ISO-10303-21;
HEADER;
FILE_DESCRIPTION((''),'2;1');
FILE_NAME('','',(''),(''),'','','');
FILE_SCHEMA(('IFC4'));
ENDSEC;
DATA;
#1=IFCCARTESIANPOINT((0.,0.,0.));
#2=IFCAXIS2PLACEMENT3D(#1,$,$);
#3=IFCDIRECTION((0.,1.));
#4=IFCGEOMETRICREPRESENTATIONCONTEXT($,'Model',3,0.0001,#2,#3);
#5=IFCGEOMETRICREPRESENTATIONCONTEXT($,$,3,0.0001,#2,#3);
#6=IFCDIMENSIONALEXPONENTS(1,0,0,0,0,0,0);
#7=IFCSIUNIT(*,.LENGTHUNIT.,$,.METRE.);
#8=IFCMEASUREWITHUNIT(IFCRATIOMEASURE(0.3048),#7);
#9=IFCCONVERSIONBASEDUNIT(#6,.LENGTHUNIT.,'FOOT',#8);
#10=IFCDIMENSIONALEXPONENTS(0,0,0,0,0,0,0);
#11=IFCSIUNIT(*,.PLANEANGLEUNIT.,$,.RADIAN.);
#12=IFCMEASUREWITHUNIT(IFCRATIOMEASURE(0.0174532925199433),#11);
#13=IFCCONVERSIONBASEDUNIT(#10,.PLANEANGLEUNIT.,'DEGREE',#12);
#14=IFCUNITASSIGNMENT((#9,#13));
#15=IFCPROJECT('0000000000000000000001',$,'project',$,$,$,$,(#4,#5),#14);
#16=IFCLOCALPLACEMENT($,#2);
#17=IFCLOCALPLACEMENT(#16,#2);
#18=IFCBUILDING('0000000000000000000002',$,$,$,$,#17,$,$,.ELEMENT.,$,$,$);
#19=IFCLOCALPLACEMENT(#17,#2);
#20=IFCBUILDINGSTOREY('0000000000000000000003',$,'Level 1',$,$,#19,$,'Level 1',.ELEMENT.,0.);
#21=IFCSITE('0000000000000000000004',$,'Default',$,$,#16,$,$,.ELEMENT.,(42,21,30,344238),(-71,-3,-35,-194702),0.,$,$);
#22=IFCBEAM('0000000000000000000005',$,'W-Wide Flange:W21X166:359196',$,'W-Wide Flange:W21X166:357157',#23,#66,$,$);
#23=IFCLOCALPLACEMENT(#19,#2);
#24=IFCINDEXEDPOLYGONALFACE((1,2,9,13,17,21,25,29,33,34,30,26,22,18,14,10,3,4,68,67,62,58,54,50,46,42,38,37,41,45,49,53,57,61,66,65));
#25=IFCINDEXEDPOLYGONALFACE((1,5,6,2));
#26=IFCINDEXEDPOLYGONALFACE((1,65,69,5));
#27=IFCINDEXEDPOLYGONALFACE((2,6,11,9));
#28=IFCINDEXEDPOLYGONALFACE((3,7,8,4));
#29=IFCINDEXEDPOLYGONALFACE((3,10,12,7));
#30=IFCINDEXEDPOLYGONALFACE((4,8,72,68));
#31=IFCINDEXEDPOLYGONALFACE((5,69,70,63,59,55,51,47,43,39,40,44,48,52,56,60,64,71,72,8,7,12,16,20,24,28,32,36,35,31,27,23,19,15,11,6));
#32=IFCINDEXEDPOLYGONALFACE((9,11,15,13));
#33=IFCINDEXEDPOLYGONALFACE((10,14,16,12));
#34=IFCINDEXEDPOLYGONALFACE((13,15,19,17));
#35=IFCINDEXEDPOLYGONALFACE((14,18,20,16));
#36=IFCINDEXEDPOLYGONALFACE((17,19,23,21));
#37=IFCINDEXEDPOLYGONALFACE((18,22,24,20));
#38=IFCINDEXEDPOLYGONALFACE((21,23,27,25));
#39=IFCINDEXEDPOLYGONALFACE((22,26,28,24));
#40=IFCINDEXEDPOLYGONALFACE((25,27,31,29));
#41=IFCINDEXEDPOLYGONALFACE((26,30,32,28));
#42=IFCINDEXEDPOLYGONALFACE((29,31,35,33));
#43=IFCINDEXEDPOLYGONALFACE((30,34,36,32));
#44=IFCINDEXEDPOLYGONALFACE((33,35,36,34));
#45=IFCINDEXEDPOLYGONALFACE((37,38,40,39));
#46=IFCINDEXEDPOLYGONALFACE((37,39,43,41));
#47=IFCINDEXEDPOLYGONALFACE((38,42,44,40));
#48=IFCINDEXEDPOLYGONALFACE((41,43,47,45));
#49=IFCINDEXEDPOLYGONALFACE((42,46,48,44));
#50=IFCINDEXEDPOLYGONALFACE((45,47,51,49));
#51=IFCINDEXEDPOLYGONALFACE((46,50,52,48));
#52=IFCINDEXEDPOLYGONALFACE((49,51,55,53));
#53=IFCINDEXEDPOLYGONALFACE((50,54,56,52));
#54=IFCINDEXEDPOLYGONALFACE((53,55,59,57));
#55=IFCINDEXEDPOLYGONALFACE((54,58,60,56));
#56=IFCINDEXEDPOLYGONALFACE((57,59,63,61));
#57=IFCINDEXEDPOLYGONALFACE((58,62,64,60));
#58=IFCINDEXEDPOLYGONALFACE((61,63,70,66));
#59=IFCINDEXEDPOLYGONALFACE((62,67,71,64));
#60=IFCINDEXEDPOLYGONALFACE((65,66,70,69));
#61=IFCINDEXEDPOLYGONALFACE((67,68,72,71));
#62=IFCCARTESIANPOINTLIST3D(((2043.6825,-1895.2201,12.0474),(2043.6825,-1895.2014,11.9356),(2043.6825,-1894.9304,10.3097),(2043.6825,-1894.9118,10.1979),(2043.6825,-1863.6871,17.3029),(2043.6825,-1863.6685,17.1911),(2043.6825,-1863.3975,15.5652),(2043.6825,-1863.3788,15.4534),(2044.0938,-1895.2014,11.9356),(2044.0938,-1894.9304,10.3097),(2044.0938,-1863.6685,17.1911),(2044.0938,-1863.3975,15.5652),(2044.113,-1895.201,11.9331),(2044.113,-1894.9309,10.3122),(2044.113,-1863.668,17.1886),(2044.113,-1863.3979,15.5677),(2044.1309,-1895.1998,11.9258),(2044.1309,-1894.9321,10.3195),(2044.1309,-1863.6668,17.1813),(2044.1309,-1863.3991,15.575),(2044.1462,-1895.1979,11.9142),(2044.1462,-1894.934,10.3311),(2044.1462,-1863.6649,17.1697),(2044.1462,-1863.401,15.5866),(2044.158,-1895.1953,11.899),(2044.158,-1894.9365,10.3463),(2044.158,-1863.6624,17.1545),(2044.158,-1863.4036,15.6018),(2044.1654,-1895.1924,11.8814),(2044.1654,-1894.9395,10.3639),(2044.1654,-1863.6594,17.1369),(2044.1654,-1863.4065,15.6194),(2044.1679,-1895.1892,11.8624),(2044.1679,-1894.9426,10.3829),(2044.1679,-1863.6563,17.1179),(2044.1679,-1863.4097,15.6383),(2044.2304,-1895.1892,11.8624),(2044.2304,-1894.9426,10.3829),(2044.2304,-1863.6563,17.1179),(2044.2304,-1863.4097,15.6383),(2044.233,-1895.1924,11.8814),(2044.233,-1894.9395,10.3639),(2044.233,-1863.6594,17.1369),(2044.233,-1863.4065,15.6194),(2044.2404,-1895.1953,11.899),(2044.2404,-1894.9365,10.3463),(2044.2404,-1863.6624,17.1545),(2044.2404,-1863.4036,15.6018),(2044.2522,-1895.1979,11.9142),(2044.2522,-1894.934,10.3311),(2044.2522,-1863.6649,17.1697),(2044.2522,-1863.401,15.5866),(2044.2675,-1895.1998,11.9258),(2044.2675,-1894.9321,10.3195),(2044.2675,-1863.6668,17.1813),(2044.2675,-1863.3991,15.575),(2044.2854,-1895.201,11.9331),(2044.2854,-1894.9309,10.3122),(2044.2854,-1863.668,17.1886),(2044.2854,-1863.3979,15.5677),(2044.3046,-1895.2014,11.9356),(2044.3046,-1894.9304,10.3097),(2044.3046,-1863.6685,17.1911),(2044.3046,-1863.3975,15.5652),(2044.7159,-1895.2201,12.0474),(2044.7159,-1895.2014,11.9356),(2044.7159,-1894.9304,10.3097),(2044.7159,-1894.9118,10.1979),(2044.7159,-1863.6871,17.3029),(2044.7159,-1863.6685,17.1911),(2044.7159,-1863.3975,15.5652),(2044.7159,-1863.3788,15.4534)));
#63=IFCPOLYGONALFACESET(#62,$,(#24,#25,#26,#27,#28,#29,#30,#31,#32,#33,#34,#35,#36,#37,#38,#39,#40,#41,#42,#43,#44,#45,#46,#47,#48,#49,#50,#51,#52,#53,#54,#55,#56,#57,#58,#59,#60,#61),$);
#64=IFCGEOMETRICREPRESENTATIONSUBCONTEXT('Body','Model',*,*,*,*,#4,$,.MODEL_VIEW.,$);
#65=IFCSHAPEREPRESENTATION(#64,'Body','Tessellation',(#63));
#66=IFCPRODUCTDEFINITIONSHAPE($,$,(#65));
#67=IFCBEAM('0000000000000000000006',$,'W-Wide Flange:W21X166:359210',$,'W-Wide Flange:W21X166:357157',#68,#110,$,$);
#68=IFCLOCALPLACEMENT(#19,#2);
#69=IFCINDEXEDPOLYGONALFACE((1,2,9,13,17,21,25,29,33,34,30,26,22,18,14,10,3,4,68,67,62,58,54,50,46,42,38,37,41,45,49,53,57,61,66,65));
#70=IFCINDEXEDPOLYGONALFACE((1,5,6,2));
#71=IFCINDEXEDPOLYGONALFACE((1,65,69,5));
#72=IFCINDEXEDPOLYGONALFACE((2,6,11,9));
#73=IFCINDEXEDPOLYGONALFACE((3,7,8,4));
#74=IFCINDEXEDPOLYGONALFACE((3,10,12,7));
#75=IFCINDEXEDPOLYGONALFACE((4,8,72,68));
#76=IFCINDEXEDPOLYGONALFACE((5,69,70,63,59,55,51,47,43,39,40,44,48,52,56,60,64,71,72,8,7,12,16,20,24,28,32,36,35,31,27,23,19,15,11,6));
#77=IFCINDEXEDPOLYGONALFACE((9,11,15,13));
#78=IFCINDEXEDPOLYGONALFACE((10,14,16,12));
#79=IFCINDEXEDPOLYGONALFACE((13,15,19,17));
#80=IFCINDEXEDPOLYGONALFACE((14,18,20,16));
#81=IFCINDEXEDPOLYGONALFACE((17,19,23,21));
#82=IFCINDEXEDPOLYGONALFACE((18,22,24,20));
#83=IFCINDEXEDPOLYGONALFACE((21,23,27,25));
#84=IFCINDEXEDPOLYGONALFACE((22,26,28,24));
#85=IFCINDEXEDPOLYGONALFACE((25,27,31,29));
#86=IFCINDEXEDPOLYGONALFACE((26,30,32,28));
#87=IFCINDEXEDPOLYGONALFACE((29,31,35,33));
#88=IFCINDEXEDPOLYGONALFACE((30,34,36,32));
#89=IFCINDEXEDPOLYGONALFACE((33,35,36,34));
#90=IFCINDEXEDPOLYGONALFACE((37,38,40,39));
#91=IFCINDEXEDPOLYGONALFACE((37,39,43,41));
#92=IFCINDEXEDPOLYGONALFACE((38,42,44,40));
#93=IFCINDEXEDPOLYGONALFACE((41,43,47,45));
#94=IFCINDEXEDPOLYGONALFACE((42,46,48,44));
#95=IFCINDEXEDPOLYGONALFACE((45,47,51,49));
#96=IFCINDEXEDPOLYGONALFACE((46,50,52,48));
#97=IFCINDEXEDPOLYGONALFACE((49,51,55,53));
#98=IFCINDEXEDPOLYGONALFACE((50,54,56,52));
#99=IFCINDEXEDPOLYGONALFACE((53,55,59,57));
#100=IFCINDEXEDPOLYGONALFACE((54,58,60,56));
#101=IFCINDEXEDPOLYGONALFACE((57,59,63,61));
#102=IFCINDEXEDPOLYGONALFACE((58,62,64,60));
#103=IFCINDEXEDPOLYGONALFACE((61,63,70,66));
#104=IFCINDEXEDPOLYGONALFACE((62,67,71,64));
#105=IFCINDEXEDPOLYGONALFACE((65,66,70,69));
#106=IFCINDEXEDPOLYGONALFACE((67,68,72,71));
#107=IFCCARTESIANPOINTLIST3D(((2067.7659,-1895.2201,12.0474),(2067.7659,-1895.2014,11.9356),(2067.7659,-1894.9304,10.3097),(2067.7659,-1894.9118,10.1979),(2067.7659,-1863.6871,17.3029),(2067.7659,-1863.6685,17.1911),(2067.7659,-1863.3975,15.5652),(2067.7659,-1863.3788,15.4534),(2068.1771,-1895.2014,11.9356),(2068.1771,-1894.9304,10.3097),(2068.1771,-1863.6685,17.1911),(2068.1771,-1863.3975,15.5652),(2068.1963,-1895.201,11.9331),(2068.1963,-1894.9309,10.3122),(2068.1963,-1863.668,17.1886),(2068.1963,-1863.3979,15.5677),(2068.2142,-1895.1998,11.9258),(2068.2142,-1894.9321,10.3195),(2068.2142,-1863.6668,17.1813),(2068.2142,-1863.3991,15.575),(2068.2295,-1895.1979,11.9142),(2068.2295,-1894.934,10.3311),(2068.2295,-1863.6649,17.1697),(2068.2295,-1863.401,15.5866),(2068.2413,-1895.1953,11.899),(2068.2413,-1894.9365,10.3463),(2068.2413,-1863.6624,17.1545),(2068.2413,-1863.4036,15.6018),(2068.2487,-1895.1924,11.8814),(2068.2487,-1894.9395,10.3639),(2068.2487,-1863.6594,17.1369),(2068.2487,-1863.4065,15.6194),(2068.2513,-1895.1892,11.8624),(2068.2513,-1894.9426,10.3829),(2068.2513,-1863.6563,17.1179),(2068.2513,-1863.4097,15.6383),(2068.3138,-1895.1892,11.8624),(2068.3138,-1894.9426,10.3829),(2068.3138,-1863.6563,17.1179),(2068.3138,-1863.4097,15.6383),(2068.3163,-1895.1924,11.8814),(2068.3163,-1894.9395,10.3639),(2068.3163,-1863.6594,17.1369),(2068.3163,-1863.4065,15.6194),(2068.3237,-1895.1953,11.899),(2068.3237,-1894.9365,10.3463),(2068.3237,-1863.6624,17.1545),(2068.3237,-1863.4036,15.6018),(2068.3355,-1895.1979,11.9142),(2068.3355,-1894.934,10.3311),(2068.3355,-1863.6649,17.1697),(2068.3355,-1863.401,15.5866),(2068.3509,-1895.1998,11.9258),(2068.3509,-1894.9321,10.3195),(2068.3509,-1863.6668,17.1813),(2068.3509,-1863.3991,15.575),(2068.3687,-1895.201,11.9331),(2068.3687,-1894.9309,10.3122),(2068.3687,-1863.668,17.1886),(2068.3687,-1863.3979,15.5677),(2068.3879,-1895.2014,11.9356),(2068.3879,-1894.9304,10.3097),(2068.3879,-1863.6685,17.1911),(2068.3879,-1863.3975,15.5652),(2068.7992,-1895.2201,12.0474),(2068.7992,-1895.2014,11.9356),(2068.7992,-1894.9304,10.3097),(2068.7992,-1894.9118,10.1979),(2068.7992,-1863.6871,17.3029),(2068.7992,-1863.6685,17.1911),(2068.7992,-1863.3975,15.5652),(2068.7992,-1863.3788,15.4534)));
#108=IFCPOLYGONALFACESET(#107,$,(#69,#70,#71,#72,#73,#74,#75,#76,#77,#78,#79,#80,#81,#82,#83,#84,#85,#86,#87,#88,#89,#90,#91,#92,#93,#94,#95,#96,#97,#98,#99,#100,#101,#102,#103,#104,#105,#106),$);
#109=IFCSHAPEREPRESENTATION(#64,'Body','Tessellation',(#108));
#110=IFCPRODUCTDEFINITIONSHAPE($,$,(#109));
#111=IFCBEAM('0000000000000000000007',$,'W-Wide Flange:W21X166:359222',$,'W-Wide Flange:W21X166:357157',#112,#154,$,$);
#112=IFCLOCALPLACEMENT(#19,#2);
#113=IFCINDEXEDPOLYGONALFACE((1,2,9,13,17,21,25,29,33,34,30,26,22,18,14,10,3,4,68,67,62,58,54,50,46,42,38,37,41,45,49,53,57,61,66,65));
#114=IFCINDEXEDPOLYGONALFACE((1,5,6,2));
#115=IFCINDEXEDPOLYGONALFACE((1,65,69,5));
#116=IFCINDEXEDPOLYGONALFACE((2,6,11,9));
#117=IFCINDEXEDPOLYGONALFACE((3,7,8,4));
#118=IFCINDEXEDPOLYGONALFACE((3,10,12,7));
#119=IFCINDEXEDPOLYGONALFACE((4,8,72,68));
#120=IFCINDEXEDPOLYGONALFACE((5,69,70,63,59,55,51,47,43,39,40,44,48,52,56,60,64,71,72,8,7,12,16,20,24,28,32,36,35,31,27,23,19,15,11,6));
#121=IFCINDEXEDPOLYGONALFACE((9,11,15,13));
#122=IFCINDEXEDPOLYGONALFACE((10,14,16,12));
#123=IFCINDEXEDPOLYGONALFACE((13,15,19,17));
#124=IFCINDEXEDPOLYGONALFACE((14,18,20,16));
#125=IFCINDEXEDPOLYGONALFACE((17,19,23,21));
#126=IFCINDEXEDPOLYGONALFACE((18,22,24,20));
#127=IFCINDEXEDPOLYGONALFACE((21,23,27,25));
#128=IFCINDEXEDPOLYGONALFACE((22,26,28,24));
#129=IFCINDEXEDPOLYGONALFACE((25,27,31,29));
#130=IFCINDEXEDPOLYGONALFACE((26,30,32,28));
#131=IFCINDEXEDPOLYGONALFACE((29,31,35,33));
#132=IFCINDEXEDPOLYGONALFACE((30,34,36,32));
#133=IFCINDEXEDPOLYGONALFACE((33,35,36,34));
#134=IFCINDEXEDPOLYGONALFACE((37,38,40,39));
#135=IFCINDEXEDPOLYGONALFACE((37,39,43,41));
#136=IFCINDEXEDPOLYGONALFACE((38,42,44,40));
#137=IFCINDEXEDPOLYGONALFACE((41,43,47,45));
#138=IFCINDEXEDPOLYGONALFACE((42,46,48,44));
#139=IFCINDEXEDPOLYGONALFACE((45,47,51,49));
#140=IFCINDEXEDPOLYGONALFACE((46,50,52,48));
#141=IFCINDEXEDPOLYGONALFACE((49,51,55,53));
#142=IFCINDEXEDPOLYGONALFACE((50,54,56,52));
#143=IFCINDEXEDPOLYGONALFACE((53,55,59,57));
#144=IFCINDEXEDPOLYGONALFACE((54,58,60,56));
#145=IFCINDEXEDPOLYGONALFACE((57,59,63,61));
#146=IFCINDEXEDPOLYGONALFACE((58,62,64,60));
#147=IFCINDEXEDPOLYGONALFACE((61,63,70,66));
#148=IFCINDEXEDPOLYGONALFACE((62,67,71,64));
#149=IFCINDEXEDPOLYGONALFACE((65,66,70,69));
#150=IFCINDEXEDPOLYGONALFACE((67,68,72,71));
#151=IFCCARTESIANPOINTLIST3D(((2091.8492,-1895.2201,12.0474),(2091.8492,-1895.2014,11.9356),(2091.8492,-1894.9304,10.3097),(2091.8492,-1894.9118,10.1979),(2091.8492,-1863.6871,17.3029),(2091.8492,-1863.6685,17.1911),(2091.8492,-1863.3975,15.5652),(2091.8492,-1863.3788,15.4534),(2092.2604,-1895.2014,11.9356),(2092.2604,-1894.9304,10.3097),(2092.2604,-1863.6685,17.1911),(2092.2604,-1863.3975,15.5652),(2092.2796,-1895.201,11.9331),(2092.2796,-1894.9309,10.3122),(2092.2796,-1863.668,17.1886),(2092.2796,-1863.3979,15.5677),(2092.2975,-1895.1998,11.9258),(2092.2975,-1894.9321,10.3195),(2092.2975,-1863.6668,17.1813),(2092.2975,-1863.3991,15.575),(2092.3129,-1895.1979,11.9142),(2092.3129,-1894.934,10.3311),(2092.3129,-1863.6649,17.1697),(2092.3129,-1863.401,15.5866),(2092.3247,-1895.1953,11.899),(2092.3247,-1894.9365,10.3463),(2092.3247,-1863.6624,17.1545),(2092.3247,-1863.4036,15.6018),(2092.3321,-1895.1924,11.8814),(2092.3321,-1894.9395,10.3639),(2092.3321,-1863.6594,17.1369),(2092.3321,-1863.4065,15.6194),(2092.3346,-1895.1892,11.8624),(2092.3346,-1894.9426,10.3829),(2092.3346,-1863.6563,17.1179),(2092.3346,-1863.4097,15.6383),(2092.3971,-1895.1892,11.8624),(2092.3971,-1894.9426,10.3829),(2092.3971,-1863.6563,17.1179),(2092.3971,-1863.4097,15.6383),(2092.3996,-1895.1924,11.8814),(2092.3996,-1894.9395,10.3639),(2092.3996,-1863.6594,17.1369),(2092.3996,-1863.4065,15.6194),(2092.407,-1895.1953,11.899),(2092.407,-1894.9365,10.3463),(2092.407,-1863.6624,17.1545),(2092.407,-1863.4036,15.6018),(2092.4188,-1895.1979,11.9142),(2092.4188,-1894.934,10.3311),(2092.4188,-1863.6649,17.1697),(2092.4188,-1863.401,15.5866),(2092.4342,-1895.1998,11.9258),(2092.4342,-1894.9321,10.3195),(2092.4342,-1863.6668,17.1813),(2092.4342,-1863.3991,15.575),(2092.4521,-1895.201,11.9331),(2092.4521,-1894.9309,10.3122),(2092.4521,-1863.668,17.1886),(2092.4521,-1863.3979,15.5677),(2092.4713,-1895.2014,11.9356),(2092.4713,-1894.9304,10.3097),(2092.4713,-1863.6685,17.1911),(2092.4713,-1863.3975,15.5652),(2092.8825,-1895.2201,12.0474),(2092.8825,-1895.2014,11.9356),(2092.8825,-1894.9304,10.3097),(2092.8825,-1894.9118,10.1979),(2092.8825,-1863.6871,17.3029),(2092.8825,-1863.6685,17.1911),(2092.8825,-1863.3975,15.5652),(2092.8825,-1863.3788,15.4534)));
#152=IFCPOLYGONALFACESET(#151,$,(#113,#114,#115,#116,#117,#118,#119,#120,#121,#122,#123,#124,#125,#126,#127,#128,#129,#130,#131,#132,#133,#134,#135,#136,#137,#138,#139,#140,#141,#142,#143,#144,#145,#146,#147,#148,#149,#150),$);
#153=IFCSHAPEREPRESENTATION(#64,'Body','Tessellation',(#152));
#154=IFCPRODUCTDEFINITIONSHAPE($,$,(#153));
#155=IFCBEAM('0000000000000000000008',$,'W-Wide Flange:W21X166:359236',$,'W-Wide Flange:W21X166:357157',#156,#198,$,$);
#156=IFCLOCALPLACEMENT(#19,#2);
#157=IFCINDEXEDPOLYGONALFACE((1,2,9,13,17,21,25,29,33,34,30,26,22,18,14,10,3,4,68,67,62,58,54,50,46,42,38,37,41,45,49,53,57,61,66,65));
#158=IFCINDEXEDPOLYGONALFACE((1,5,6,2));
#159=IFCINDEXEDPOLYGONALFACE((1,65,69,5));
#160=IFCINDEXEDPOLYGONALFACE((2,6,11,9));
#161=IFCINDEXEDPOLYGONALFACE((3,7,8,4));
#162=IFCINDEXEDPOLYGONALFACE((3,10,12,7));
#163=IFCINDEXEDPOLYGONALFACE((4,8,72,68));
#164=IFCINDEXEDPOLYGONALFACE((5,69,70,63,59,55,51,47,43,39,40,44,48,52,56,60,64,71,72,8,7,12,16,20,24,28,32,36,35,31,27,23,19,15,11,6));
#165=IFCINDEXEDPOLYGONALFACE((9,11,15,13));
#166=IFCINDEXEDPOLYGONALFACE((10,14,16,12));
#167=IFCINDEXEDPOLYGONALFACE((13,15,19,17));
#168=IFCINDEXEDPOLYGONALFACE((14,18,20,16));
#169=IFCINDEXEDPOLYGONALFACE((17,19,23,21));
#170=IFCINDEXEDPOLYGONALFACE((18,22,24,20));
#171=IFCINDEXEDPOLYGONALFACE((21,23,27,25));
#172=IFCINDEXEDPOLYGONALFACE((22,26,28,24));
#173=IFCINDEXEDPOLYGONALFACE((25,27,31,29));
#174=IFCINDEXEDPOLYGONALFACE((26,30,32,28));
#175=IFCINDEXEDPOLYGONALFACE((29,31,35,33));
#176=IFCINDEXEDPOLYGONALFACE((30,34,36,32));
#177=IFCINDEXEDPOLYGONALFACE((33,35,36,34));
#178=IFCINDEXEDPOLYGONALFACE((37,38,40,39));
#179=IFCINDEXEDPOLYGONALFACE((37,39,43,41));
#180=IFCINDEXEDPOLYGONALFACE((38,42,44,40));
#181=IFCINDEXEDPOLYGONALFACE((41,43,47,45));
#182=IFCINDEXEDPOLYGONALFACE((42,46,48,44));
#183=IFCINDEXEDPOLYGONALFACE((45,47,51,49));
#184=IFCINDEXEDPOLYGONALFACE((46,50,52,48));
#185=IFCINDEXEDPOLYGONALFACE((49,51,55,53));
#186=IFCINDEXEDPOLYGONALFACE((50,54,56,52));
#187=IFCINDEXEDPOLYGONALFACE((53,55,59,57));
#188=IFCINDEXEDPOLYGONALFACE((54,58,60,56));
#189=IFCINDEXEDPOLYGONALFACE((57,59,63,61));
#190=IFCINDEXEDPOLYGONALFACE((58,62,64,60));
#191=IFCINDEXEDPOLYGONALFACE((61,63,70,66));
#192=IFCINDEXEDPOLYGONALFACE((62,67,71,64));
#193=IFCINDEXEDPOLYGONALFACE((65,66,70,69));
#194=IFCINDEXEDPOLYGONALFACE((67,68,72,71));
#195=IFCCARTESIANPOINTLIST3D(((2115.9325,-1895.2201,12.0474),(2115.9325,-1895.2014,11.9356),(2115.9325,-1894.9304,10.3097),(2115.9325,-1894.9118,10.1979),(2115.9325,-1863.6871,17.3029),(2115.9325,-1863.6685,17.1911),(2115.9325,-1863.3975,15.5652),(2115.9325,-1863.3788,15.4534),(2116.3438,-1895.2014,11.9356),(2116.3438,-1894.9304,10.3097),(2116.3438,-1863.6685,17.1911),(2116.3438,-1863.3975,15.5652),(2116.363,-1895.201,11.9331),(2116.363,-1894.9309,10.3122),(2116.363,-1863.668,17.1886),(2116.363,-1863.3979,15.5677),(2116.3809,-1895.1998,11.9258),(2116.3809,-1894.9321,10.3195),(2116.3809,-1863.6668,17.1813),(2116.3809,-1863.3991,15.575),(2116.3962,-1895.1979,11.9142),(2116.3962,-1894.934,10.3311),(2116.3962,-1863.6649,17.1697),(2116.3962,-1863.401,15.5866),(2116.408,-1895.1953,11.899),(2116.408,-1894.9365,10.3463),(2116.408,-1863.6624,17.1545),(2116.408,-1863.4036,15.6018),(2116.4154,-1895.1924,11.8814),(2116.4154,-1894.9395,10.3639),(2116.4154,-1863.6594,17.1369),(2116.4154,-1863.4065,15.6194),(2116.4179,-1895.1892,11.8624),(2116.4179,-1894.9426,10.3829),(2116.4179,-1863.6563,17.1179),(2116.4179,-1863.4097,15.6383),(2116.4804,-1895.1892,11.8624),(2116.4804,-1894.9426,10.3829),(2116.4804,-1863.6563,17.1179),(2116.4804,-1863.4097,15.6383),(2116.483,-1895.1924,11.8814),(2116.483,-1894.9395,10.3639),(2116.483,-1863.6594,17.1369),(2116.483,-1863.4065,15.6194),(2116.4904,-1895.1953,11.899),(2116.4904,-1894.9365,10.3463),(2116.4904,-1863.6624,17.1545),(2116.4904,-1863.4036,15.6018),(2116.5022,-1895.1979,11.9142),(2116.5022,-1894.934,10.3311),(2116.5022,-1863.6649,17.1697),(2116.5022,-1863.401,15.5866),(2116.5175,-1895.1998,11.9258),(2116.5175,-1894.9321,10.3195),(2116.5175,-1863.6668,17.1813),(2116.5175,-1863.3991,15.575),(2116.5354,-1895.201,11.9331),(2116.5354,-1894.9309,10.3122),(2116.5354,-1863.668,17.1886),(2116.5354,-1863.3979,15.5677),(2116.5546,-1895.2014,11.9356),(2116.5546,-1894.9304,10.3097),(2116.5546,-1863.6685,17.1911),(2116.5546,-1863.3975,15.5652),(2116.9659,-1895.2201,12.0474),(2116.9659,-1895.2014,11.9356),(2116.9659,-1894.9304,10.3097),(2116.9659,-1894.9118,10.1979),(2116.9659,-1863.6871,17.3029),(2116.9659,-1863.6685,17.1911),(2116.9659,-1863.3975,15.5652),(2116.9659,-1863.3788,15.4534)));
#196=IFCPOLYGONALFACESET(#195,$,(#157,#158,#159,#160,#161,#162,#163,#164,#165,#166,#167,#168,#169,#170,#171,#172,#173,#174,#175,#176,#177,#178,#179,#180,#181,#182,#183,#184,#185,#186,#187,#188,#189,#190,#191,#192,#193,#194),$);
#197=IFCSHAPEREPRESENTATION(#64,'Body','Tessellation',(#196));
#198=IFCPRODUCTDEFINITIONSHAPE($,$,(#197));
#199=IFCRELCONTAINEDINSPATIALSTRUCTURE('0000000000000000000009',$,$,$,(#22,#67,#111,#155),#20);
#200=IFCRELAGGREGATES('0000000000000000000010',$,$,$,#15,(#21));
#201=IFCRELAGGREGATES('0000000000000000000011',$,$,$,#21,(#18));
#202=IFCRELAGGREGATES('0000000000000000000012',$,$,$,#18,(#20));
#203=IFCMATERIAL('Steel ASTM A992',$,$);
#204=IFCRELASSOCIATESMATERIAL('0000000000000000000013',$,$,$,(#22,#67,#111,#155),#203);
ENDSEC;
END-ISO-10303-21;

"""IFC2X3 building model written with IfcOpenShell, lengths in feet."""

from ifc_helpers import new_model, entity, si_unit, converted_unit, direction, frame, frame_2d, origin, place, context, subcontext, project, spatial, i_section, extrude, material, element, save


model = new_model("IFC2X3")

# Units and contexts
model_context = context("Model", 3, precision=0.0001, world=origin(), true_north=direction((0.0, 1.0)))
context_of_model = context(None, 3, precision=0.0001, world=origin(), true_north=direction((0.0, 1.0)))
body_context = subcontext(model_context, "Body", "Model", "MODEL_VIEW")
ifc_project = project(units=[converted_unit("LENGTHUNIT", "FOOT", entity("IfcRatioMeasure", 0.3048), si_unit("LENGTHUNIT", "METRE"), dimensions=[1, 0, 0, 0, 0, 0, 0]), converted_unit("PLANEANGLEUNIT", "DEGREE", entity("IfcRatioMeasure", 0.0174532925199433), si_unit("PLANEANGLEUNIT", "RADIAN"), dimensions=[0, 0, 0, 0, 0, 0, 0])], contexts=[model_context, context_of_model])

# Site, building, storey
site_placement = place(None, origin())
site = spatial("IfcSite", under=ifc_project, at=site_placement, Name="Default", CompositionType="ELEMENT", RefLatitude=(42, 21, 30, 344238), RefLongitude=(-71, -3, -35, -194702), RefElevation=0.0)
building_placement = place(site_placement, origin())
building = spatial("IfcBuilding", under=site, at=building_placement, CompositionType="ELEMENT")
storey_placement = place(building_placement, origin())
storey = spatial("IfcBuildingStorey", under=building, at=storey_placement, Name="Level 1", LongName="Level 1", CompositionType="ELEMENT", Elevation=0.0)

# Beams
ifc_material_1 = material(Name="Steel ASTM A992")
beam_1_placement = place(storey_placement, frame((2044.1992, -1895.6585, 11.9743), z_axis=(0.0, -0.164399, 0.986394), x_axis=(0.0, 0.986394, 0.164399)))
element("IfcBeam", 1, at=beam_1_placement, inside=storey, material=ifc_material_1, Name="W-Wide Flange:W21X166:359196", ObjectType="W-Wide Flange:W21X166:357157", context=body_context, shape_type="SweptSolid", body=[
    extrude(i_section(OverallWidth=1.0333, OverallDepth=1.875, WebThickness=0.0625, FlangeThickness=0.1133, FilletRadius=0.0742, at=frame_2d((0.0, 0.0), x_axis=(0.0, 1.0))), frame((0.4445, 0.0, -0.9375), z_axis=(1.0, 0.0, 0.0), x_axis=(0.0, 0.0, -1.0)), (0.0, 0.0, 1.0), 31.9679),
])
beam_2_placement = place(storey_placement, frame((2068.2825, -1895.6585, 11.9743), z_axis=(0.0, -0.164399, 0.986394), x_axis=(0.0, 0.986394, 0.164399)))
element("IfcBeam", 2, at=beam_2_placement, inside=storey, material=ifc_material_1, Name="W-Wide Flange:W21X166:359210", ObjectType="W-Wide Flange:W21X166:357157", context=body_context, shape_type="SweptSolid", body=[
    extrude(i_section(OverallWidth=1.0333, OverallDepth=1.875, WebThickness=0.0625, FlangeThickness=0.1133, FilletRadius=0.0742, at=frame_2d((0.0, 0.0), x_axis=(0.0, 1.0))), frame((0.4445, 0.0, -0.9375), z_axis=(1.0, 0.0, 0.0), x_axis=(0.0, 0.0, -1.0)), (0.0, 0.0, 1.0), 31.9679),
])
beam_3_placement = place(storey_placement, frame((2092.3659, -1895.6585, 11.9743), z_axis=(0.0, -0.164399, 0.986394), x_axis=(0.0, 0.986394, 0.164399)))
element("IfcBeam", 3, at=beam_3_placement, inside=storey, material=ifc_material_1, Name="W-Wide Flange:W21X166:359222", ObjectType="W-Wide Flange:W21X166:357157", context=body_context, shape_type="SweptSolid", body=[
    extrude(i_section(OverallWidth=1.0333, OverallDepth=1.875, WebThickness=0.0625, FlangeThickness=0.1133, FilletRadius=0.0742, at=frame_2d((0.0, 0.0), x_axis=(0.0, 1.0))), frame((0.4445, 0.0, -0.9375), z_axis=(1.0, 0.0, 0.0), x_axis=(0.0, 0.0, -1.0)), (0.0, 0.0, 1.0), 31.9679),
])
beam_4_placement = place(storey_placement, frame((2116.4492, -1895.6585, 11.9743), z_axis=(0.0, -0.164399, 0.986394), x_axis=(0.0, 0.986394, 0.164399)))
element("IfcBeam", 4, at=beam_4_placement, inside=storey, material=ifc_material_1, Name="W-Wide Flange:W21X166:359236", ObjectType="W-Wide Flange:W21X166:357157", context=body_context, shape_type="SweptSolid", body=[
    extrude(i_section(OverallWidth=1.0333, OverallDepth=1.875, WebThickness=0.0625, FlangeThickness=0.1133, FilletRadius=0.0742, at=frame_2d((0.0, 0.0), x_axis=(0.0, 1.0))), frame((0.4445, 0.0, -0.9375), z_axis=(1.0, 0.0, 0.0), x_axis=(0.0, 0.0, -1.0)), (0.0, 0.0, 1.0), 31.9679),
])

save(model, "model.ifc")
